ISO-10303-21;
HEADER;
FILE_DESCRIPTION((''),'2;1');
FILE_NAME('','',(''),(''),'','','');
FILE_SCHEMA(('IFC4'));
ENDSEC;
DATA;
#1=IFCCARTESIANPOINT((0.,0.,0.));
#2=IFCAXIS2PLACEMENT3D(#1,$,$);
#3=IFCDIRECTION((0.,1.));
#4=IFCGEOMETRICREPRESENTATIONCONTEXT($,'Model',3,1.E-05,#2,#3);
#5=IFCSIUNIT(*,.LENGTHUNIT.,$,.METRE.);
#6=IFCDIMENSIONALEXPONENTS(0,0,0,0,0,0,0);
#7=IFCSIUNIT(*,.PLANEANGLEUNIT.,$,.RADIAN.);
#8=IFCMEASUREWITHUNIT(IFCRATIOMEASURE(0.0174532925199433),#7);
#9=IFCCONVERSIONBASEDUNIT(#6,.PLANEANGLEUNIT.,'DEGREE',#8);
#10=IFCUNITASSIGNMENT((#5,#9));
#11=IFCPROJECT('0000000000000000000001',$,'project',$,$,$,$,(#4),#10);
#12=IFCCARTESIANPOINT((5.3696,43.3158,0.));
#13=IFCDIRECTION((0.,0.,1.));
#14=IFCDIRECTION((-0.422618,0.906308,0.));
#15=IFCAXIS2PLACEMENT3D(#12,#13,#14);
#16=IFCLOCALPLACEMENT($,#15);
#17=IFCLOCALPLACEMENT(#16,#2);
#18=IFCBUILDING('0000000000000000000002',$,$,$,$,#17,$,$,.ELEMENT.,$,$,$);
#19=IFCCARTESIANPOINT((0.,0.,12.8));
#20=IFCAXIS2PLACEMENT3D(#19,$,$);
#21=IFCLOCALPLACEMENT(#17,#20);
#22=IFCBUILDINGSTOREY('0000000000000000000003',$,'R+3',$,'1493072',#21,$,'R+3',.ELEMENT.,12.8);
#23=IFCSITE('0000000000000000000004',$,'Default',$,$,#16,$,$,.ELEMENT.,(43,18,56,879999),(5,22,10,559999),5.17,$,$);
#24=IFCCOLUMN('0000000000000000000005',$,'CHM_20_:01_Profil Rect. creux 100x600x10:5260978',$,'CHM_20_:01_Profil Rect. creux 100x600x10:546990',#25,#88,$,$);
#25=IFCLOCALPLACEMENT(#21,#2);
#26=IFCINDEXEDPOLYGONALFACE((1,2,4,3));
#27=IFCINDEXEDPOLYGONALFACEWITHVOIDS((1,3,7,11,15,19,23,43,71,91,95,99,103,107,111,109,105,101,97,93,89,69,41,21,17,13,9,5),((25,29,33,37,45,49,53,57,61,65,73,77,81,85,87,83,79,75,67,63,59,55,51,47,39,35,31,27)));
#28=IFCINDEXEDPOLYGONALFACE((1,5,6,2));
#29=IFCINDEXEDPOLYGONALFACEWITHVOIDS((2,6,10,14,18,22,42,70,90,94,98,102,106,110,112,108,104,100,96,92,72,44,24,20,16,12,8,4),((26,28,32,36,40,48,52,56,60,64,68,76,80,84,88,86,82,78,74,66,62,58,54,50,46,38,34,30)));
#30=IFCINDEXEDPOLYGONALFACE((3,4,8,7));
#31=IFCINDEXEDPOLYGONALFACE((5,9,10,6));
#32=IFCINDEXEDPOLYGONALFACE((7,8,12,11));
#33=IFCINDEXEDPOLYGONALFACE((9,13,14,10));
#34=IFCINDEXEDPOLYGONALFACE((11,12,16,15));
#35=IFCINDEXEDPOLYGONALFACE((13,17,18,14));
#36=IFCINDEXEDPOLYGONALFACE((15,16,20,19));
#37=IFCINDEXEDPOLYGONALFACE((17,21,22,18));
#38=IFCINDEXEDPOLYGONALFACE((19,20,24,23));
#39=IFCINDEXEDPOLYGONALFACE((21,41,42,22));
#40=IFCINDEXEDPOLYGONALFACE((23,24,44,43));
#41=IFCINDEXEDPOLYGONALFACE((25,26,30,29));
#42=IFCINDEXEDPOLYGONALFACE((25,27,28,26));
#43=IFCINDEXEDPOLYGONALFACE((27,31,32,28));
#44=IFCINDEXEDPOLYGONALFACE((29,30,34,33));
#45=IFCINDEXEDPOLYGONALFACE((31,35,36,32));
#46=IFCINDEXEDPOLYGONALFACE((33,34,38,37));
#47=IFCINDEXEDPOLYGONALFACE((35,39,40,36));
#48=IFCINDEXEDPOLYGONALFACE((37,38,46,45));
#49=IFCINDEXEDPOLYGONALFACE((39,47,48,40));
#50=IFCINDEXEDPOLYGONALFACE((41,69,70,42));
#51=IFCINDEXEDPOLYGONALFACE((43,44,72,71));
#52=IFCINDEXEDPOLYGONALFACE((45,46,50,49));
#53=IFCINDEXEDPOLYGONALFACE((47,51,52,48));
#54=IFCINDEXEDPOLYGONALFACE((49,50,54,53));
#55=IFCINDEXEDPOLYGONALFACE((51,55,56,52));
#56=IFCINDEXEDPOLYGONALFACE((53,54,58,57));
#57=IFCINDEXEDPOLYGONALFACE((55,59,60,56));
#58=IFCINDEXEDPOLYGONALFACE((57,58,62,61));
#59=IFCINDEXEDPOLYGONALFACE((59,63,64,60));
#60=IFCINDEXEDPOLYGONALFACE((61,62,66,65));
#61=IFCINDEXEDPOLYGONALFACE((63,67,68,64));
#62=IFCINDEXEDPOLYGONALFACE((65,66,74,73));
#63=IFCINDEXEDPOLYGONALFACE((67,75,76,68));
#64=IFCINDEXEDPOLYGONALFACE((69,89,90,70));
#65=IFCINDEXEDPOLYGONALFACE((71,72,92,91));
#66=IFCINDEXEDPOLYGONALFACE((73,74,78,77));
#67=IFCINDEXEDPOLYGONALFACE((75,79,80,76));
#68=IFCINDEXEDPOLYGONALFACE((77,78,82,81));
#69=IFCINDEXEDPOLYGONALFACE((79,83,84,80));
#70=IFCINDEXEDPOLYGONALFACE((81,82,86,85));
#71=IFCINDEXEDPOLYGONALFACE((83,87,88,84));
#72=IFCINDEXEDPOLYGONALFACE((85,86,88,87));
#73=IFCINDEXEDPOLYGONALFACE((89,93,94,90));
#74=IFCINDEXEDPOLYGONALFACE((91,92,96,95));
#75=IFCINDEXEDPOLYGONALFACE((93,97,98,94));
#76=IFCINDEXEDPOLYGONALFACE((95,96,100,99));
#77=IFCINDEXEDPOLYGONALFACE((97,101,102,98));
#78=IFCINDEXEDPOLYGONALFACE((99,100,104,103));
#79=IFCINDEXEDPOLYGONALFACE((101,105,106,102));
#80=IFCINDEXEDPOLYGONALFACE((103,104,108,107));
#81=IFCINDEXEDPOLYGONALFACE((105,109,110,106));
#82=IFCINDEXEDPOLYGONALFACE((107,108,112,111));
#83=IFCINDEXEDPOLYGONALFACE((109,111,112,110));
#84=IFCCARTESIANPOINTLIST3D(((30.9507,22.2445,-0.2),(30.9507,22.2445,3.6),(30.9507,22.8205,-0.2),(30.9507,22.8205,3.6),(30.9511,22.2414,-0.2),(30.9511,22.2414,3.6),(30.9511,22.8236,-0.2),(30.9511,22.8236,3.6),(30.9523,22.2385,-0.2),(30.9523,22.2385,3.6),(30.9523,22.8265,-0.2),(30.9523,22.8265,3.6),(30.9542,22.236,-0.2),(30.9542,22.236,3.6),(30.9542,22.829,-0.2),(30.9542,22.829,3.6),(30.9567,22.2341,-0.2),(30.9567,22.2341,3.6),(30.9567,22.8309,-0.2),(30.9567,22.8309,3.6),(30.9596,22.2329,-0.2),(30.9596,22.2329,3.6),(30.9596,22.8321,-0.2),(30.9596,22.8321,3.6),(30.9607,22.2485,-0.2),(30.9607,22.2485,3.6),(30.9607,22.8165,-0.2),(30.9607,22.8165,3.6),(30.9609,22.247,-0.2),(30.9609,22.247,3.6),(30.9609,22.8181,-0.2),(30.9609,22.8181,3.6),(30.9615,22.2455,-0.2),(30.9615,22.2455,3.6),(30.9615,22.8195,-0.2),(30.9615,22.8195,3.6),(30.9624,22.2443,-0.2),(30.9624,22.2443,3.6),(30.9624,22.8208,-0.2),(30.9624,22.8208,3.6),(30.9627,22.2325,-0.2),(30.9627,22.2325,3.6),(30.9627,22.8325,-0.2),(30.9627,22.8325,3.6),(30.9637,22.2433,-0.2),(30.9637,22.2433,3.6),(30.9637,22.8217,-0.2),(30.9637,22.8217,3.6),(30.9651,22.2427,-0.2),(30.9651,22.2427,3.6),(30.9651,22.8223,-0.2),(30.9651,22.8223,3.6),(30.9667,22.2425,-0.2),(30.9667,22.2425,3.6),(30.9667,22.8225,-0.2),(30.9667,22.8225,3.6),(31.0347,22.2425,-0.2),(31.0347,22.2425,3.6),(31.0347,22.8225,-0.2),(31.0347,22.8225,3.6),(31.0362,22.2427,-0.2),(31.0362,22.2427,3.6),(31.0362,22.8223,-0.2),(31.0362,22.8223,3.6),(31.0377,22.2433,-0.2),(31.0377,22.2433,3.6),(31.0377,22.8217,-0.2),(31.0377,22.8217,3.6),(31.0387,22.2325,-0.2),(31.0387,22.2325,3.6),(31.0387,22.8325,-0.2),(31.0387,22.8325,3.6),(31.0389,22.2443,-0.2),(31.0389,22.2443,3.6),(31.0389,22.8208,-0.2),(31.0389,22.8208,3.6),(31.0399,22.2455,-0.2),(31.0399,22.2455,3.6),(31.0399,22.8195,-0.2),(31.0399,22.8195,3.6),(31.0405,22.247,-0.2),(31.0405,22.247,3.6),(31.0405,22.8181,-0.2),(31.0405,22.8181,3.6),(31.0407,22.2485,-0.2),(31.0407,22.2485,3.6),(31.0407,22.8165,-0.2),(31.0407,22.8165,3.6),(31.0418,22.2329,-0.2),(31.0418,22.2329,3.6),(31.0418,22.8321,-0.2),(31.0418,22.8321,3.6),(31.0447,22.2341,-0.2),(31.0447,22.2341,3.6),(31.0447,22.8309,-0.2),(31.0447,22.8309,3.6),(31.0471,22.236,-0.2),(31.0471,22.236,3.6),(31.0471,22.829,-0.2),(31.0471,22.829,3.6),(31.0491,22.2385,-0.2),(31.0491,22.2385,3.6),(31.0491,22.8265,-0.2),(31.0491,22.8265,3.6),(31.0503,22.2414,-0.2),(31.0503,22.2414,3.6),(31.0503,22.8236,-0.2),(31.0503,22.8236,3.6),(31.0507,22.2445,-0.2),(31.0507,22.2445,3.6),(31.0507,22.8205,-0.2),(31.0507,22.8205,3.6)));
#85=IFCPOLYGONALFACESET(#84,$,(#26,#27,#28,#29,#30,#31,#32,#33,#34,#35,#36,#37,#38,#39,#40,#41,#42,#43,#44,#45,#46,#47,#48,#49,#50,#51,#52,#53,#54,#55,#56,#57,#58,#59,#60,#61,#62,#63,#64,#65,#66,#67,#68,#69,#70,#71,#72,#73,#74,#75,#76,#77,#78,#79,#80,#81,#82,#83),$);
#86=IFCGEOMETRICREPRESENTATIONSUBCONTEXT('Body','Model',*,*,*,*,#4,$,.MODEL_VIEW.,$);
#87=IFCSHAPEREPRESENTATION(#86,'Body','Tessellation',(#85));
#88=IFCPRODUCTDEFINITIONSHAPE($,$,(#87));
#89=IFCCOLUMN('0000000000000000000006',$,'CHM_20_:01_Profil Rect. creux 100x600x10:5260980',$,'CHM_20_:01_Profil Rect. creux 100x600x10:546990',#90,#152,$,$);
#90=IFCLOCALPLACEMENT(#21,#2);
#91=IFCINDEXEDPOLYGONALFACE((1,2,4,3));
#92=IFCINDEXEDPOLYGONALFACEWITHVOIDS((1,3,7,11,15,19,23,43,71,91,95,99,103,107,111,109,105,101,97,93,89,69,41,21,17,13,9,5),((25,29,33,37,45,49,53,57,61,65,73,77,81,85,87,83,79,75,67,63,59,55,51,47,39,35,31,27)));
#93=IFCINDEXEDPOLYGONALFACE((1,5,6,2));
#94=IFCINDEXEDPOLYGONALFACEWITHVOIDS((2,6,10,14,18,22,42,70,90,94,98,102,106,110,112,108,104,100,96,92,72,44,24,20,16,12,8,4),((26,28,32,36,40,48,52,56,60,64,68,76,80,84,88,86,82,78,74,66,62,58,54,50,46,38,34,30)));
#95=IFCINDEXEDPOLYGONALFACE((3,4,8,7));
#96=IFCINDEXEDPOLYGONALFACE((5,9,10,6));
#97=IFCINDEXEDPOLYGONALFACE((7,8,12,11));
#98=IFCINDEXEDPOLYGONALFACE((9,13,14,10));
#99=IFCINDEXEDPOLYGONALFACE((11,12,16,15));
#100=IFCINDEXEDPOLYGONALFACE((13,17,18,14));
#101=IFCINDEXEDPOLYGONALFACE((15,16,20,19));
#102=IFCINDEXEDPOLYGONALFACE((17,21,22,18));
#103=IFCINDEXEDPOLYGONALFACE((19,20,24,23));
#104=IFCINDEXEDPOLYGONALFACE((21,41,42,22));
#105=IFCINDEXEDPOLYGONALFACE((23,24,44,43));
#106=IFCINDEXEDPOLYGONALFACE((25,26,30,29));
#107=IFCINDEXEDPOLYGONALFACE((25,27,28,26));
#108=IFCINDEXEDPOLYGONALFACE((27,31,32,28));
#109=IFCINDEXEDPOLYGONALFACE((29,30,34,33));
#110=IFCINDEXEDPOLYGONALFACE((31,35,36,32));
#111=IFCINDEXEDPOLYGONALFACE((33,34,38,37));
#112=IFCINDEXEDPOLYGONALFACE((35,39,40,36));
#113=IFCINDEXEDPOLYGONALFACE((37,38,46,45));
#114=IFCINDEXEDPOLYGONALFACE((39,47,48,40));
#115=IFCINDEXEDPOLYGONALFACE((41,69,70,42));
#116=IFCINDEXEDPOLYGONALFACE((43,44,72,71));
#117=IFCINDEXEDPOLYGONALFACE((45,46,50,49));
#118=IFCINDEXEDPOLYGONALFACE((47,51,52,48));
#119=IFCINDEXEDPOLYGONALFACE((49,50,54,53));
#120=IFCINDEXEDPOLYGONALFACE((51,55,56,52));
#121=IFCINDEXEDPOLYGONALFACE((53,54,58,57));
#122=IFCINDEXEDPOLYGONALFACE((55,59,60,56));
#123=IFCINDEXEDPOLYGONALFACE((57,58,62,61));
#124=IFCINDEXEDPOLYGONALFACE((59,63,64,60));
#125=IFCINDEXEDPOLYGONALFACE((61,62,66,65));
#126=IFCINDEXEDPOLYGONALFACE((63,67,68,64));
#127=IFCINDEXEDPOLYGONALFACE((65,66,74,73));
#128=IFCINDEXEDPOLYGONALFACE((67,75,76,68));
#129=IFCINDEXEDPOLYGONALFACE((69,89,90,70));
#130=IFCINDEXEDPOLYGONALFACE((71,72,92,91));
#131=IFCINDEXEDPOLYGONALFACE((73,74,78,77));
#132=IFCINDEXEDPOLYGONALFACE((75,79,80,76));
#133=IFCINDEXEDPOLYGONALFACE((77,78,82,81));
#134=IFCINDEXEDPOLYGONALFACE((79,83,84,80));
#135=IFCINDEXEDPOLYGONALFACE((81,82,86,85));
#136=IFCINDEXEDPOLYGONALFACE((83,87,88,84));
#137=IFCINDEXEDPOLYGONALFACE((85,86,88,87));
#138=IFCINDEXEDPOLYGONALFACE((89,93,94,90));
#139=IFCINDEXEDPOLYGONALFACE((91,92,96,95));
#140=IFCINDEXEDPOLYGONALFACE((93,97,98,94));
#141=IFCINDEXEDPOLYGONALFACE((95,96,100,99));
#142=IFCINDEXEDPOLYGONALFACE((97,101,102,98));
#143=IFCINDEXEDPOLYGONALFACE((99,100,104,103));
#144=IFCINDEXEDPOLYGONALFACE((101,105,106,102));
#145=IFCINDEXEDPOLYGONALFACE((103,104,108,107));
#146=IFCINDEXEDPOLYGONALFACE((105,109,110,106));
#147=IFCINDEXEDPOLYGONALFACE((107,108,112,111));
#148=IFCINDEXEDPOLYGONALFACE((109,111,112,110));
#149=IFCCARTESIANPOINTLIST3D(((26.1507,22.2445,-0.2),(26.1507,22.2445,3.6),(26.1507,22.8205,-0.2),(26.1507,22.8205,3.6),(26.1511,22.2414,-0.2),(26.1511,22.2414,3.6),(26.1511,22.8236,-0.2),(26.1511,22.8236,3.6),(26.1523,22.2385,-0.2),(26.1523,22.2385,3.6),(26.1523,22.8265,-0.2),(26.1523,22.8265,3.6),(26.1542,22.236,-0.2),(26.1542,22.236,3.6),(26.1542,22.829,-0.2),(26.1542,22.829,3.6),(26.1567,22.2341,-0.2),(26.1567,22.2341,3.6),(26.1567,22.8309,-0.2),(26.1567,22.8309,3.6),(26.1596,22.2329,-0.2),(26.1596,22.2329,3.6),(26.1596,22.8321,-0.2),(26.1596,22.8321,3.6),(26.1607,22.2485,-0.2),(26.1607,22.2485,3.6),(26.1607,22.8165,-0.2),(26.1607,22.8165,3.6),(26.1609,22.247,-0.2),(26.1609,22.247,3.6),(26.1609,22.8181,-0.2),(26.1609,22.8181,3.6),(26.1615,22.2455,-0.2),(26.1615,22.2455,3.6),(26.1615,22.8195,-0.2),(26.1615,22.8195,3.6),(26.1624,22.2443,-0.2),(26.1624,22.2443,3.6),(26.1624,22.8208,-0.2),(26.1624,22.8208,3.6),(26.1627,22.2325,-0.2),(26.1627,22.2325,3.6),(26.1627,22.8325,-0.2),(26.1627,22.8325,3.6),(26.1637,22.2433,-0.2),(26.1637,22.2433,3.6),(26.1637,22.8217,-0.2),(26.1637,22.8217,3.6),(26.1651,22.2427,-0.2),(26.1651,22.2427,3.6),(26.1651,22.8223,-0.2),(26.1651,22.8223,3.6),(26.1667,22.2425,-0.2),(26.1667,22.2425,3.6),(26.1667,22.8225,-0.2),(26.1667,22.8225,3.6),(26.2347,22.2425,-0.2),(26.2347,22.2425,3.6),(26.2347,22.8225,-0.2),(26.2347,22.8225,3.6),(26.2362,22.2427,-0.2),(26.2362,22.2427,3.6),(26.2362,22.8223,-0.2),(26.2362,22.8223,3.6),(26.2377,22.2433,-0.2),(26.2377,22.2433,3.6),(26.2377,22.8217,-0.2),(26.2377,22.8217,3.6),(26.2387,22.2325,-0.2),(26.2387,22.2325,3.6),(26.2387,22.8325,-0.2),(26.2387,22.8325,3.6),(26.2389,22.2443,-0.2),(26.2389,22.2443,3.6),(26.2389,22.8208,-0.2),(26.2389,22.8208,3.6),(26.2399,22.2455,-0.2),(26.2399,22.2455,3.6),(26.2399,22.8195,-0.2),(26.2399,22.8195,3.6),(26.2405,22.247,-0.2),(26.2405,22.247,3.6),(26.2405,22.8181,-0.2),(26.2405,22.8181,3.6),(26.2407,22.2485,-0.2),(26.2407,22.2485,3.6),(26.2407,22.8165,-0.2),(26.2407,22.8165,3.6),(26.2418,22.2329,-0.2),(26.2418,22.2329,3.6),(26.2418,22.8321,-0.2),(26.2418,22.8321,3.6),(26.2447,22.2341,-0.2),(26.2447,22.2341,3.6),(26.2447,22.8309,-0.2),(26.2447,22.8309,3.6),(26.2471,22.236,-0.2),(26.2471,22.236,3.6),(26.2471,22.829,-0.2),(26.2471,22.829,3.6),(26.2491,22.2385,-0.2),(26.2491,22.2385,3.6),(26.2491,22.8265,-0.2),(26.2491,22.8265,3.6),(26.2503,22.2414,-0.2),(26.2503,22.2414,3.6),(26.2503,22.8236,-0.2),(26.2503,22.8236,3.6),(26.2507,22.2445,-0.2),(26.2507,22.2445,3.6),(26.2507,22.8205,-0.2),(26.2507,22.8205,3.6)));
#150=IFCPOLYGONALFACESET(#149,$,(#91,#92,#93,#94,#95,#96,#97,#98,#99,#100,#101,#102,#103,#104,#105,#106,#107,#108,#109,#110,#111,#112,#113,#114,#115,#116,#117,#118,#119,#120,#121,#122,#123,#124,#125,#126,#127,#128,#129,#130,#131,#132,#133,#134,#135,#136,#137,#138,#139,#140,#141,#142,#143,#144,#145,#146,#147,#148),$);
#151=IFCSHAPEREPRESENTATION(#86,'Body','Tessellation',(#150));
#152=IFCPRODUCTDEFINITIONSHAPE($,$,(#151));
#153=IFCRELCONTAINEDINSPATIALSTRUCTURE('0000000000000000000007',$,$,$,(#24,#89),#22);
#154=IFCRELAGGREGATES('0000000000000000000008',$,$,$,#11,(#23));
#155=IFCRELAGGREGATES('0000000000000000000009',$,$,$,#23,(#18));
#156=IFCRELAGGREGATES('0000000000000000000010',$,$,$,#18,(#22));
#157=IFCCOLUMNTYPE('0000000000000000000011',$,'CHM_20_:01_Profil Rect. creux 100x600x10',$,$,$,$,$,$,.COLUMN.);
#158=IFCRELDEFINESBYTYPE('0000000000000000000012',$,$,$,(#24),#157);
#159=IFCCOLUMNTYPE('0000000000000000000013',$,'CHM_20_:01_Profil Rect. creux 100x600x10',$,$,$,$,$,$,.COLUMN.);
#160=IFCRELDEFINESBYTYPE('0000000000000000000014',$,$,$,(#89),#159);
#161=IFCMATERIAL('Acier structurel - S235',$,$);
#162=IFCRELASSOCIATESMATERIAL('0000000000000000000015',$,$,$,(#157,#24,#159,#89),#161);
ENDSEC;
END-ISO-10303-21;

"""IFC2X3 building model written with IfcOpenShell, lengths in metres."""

from ifc_helpers import new_model, entity, si_unit, converted_unit, direction, frame, frame_2d, origin, place, context, subcontext, project, spatial, polyline, circle_curve, parameter, trimmed, segment, composite_curve, outline, extrude, source, transform, mapped, material, type_object, type_shapes, element, save


model = new_model("IFC2X3")

# Units and contexts
model_context = context("Model", 3, precision=1e-05, world=origin(), true_north=direction((0.0, 1.0)))
body_context = subcontext(model_context, "Body", "Model", "MODEL_VIEW")
ifc_project = project(units=[si_unit("LENGTHUNIT", "METRE"), converted_unit("PLANEANGLEUNIT", "DEGREE", entity("IfcRatioMeasure", 0.0174532925199433), si_unit("PLANEANGLEUNIT", "RADIAN"), dimensions=[0, 0, 0, 0, 0, 0, 0])], contexts=[model_context])

# Site, building, storey
site_placement = place(None, frame((5.3696, 43.3158, 0.0), z_axis=(0.0, 0.0, 1.0), x_axis=(-0.422618, 0.906308, 0.0)))
site = spatial("IfcSite", under=ifc_project, at=site_placement, Name="Default", CompositionType="ELEMENT", RefLatitude=(43, 18, 56, 879999), RefLongitude=(5, 22, 10, 559999), RefElevation=5.17)
building_placement = place(site_placement, origin())
building = spatial("IfcBuilding", under=site, at=building_placement, CompositionType="ELEMENT")
storey_placement = place(building_placement, frame((0.0, 0.0, 12.8)))
storey = spatial("IfcBuildingStorey", under=building, at=storey_placement, Name="R+3", ObjectType="1493072", LongName="R+3", CompositionType="ELEMENT", Elevation=12.8)

# Columns
ifc_material_1 = material(Name="Acier structurel - S235")
column_type_1 = type_object("IfcColumnType", Name="CHM_20_:01_Profil Rect. creux 100x600x10", PredefinedType="COLUMN", material=ifc_material_1)
shared_shape_1 = source(origin(), body_context, "Body", "SweptSolid", [
    extrude(outline(composite_curve([segment(polyline([(-0.038, -0.3), (0.038, -0.3)]), True, "CONTINUOUS"), segment(trimmed(circle_curve(frame_2d((0.038, -0.288), x_axis=(-1.0, 0.0)), 0.012), [parameter(90.0)], [parameter(180.0)], True, "PARAMETER"), True, "CONTINUOUS"), segment(polyline([(0.05, -0.288), (0.05, 0.288)]), True, "CONTINUOUS"), segment(trimmed(circle_curve(frame_2d((0.038, 0.288), x_axis=(-1.0, 0.0)), 0.012), [parameter(180.0)], [parameter(270.0)], True, "PARAMETER"), True, "CONTINUOUS"), segment(polyline([(0.038, 0.3), (-0.038, 0.3)]), True, "CONTINUOUS"), segment(trimmed(circle_curve(frame_2d((-0.038, 0.288), x_axis=(-1.0, 0.0)), 0.012), [parameter(270.0)], [parameter(360.0)], True, "PARAMETER"), True, "CONTINUOUS"), segment(polyline([(-0.05, 0.288), (-0.05, -0.288)]), True, "CONTINUOUS"), segment(trimmed(circle_curve(frame_2d((-0.038, -0.288), x_axis=(-1.0, 0.0)), 0.012), [parameter(360.0)], [parameter(90.0)], True, "PARAMETER"), True, "CONTINUOUS")], self_intersect=False), holes=[composite_curve([segment(trimmed(circle_curve(frame_2d((-0.034, -0.284), x_axis=(-1.0, 0.0)), 0.006), [parameter(0.0)], [parameter(90.0)], True, "PARAMETER"), False, "CONTINUOUS"), segment(polyline([(-0.04, -0.284), (-0.04, 0.284)]), True, "CONTINUOUS"), segment(trimmed(circle_curve(frame_2d((-0.034, 0.284), x_axis=(-1.0, 0.0)), 0.006), [parameter(270.0)], [parameter(0.0)], True, "PARAMETER"), False, "CONTINUOUS"), segment(polyline([(-0.034, 0.29), (0.034, 0.29)]), True, "CONTINUOUS"), segment(trimmed(circle_curve(frame_2d((0.034, 0.284), x_axis=(-1.0, 0.0)), 0.006), [parameter(180.0)], [parameter(270.0)], True, "PARAMETER"), False, "CONTINUOUS"), segment(polyline([(0.04, 0.284), (0.04, -0.284)]), True, "CONTINUOUS"), segment(trimmed(circle_curve(frame_2d((0.034, -0.284), x_axis=(-1.0, 0.0)), 0.006), [parameter(90.0)], [parameter(180.0)], True, "PARAMETER"), False, "CONTINUOUS"), segment(polyline([(0.034, -0.29), (-0.034, -0.29)]), True, "CONTINUOUS")], self_intersect=False)]), frame((31.0007, 22.5325, 12.6)), (0.0, 0.0, 1.0), 3.8),
])
type_shapes(column_type_1, [shared_shape_1])
column_1_placement = place(storey_placement, frame((0.0, 0.0, -12.8)))
element("IfcColumn", 1, at=column_1_placement, inside=storey, type_object=column_type_1, material=ifc_material_1, Name="CHM_20_:01_Profil Rect. creux 100x600x10:5260978", ObjectType="CHM_20_:01_Profil Rect. creux 100x600x10:546990", context=body_context, shape_type="MappedRepresentation", body=[
    mapped(shared_shape_1, transform((0.0, 0.0, 0.0), scale=1.0)),
])
column_type_2 = type_object("IfcColumnType", Name="CHM_20_:01_Profil Rect. creux 100x600x10", PredefinedType="COLUMN", material=ifc_material_1)
shared_shape_2 = source(origin(), body_context, "Body", "SweptSolid", [
    extrude(outline(composite_curve([segment(polyline([(-0.038, -0.3), (0.038, -0.3)]), True, "CONTINUOUS"), segment(trimmed(circle_curve(frame_2d((0.038, -0.288), x_axis=(-1.0, 0.0)), 0.012), [parameter(90.0)], [parameter(180.0)], True, "PARAMETER"), True, "CONTINUOUS"), segment(polyline([(0.05, -0.288), (0.05, 0.288)]), True, "CONTINUOUS"), segment(trimmed(circle_curve(frame_2d((0.038, 0.288), x_axis=(-1.0, 0.0)), 0.012), [parameter(180.0)], [parameter(270.0)], True, "PARAMETER"), True, "CONTINUOUS"), segment(polyline([(0.038, 0.3), (-0.038, 0.3)]), True, "CONTINUOUS"), segment(trimmed(circle_curve(frame_2d((-0.038, 0.288), x_axis=(-1.0, 0.0)), 0.012), [parameter(270.0)], [parameter(360.0)], True, "PARAMETER"), True, "CONTINUOUS"), segment(polyline([(-0.05, 0.288), (-0.05, -0.288)]), True, "CONTINUOUS"), segment(trimmed(circle_curve(frame_2d((-0.038, -0.288), x_axis=(-1.0, 0.0)), 0.012), [parameter(360.0)], [parameter(90.0)], True, "PARAMETER"), True, "CONTINUOUS")], self_intersect=False), holes=[composite_curve([segment(trimmed(circle_curve(frame_2d((-0.034, -0.284), x_axis=(-1.0, 0.0)), 0.006), [parameter(0.0)], [parameter(90.0)], True, "PARAMETER"), False, "CONTINUOUS"), segment(polyline([(-0.04, -0.284), (-0.04, 0.284)]), True, "CONTINUOUS"), segment(trimmed(circle_curve(frame_2d((-0.034, 0.284), x_axis=(-1.0, 0.0)), 0.006), [parameter(270.0)], [parameter(0.0)], True, "PARAMETER"), False, "CONTINUOUS"), segment(polyline([(-0.034, 0.29), (0.034, 0.29)]), True, "CONTINUOUS"), segment(trimmed(circle_curve(frame_2d((0.034, 0.284), x_axis=(-1.0, 0.0)), 0.006), [parameter(180.0)], [parameter(270.0)], True, "PARAMETER"), False, "CONTINUOUS"), segment(polyline([(0.04, 0.284), (0.04, -0.284)]), True, "CONTINUOUS"), segment(trimmed(circle_curve(frame_2d((0.034, -0.284), x_axis=(-1.0, 0.0)), 0.006), [parameter(90.0)], [parameter(180.0)], True, "PARAMETER"), False, "CONTINUOUS"), segment(polyline([(0.034, -0.29), (-0.034, -0.29)]), True, "CONTINUOUS")], self_intersect=False)]), frame((26.2007, 22.5325, 12.6)), (0.0, 0.0, 1.0), 3.8),
])
type_shapes(column_type_2, [shared_shape_2])
column_2_placement = place(storey_placement, frame((0.0, 0.0, -12.8)))
element("IfcColumn", 2, at=column_2_placement, inside=storey, type_object=column_type_2, material=ifc_material_1, Name="CHM_20_:01_Profil Rect. creux 100x600x10:5260980", ObjectType="CHM_20_:01_Profil Rect. creux 100x600x10:546990", context=body_context, shape_type="MappedRepresentation", body=[
    mapped(shared_shape_2, transform((0.0, 0.0, 0.0), scale=1.0)),
])

save(model, "model.ifc")
